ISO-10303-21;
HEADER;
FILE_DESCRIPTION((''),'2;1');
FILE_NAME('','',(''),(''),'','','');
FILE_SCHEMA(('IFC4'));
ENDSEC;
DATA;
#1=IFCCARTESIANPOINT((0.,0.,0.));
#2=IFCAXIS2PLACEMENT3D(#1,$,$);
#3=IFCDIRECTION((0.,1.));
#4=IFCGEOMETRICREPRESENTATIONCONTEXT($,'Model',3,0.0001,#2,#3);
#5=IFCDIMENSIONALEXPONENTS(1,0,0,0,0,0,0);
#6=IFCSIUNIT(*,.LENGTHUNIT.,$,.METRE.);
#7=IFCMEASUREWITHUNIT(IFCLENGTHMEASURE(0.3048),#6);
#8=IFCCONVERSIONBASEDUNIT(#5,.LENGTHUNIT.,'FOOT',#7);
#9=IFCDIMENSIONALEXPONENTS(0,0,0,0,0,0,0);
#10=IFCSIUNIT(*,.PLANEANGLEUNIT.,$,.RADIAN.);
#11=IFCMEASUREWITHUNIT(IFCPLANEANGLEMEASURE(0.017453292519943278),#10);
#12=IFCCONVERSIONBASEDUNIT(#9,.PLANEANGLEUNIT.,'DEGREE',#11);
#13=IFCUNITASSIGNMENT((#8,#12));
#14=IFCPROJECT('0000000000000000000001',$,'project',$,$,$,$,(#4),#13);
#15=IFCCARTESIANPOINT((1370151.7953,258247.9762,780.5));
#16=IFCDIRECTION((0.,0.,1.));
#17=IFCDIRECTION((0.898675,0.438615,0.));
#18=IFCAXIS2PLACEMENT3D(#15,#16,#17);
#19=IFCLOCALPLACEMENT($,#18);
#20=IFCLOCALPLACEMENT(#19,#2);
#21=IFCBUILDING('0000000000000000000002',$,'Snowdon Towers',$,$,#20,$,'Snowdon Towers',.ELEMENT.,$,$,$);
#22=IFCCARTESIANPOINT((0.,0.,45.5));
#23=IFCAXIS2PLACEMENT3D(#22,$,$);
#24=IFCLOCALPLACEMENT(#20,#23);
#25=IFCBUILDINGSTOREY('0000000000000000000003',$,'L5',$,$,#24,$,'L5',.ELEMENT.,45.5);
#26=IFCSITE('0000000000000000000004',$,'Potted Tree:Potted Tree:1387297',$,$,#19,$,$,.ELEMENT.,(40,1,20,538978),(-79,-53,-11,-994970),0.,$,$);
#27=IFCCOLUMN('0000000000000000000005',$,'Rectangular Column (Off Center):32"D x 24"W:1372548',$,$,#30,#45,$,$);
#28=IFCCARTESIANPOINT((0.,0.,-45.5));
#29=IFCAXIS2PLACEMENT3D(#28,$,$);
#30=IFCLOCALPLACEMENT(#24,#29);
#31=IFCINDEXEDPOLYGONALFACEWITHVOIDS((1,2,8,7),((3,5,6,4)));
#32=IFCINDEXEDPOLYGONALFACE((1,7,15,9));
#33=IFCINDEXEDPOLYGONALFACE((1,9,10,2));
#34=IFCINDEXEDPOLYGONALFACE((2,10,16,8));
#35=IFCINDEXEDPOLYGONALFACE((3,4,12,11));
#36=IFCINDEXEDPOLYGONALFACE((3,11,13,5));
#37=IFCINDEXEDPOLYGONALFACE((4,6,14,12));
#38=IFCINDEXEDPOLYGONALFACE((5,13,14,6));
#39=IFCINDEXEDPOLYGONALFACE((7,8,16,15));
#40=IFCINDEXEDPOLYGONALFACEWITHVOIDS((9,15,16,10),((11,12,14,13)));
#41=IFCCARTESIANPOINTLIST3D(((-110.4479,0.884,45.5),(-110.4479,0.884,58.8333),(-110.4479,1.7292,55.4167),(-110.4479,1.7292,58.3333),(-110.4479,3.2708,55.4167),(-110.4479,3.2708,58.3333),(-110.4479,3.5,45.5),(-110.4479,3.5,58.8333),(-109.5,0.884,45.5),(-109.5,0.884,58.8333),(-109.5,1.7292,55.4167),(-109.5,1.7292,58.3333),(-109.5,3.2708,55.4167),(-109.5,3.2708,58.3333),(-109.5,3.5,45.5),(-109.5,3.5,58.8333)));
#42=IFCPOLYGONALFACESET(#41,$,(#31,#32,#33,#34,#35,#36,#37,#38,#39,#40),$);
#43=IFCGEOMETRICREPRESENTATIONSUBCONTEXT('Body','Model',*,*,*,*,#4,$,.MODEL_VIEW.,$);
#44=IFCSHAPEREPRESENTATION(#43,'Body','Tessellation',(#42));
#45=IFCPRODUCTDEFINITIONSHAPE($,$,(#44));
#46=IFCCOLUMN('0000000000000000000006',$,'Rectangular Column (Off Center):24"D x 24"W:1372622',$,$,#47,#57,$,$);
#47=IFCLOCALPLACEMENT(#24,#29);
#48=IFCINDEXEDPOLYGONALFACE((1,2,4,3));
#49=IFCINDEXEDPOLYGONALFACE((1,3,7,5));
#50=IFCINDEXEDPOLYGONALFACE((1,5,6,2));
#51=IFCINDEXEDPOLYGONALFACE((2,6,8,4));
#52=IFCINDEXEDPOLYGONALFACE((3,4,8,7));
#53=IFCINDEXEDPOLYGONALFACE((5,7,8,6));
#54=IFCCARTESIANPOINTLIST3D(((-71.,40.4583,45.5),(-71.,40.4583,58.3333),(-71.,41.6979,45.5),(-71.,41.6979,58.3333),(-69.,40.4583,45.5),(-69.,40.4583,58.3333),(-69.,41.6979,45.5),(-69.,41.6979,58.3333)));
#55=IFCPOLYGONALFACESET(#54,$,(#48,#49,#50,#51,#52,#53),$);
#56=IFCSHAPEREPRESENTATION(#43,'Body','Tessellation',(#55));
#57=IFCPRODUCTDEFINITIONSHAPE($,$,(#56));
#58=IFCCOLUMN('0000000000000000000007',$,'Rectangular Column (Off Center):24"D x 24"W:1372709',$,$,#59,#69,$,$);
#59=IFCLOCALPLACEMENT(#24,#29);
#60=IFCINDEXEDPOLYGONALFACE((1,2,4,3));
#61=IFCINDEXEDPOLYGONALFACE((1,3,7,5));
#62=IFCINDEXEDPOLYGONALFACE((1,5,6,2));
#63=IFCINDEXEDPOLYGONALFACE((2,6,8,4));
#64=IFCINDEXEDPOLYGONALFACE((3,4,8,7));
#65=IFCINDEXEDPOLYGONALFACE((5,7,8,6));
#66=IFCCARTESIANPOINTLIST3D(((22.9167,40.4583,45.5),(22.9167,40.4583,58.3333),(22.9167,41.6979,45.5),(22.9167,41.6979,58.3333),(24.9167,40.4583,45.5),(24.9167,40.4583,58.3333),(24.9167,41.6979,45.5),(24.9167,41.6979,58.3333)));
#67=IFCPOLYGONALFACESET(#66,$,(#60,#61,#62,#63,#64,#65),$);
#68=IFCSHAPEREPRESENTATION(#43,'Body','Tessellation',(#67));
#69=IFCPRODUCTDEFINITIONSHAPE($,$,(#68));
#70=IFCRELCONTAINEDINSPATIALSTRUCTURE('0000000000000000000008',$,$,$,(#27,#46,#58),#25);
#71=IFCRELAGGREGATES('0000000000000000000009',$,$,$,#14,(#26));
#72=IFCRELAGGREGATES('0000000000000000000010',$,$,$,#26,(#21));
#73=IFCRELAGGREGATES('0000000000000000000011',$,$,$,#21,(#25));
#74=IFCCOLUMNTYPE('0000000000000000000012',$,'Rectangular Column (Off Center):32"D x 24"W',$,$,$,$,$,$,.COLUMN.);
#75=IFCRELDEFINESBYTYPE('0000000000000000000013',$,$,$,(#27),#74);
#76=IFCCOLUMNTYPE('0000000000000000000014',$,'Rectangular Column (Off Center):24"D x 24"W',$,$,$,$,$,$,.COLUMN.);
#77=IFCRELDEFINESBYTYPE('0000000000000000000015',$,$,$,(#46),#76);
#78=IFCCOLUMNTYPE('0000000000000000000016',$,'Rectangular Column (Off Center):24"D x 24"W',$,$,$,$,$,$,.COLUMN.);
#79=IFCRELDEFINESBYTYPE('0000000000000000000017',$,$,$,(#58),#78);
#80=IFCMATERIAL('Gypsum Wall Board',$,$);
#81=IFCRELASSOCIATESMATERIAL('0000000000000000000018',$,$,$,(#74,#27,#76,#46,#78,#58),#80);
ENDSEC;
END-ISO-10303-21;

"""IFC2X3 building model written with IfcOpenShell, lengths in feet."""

from ifc_helpers import new_model, entity, si_unit, converted_unit, direction, frame, frame_2d, origin, place, context, subcontext, project, spatial, rectangle, extrude, source, transform, mapped, material, type_object, type_shapes, element, save


model = new_model("IFC2X3")

# Units and contexts
model_context = context("Model", 3, precision=0.0001, world=origin(), true_north=direction((0.0, 1.0)))
body_context = subcontext(model_context, "Body", "Model", "MODEL_VIEW")
ifc_project = project(units=[converted_unit("LENGTHUNIT", "FOOT", entity("IfcLengthMeasure", 0.3048), si_unit("LENGTHUNIT", "METRE"), dimensions=[1, 0, 0, 0, 0, 0, 0]), converted_unit("PLANEANGLEUNIT", "DEGREE", entity("IfcPlaneAngleMeasure", 0.017453292519943278), si_unit("PLANEANGLEUNIT", "RADIAN"), dimensions=[0, 0, 0, 0, 0, 0, 0])], contexts=[model_context])

# Site, building, storey
site_placement = place(None, frame((1370151.7953, 258247.9762, 780.5), z_axis=(0.0, 0.0, 1.0), x_axis=(0.898675, 0.438615, 0.0)))
site = spatial("IfcSite", under=ifc_project, at=site_placement, Name="Potted Tree:Potted Tree:1387297", CompositionType="ELEMENT", RefLatitude=(40, 1, 20, 538978), RefLongitude=(-79, -53, -11, -994970), RefElevation=0.0)
building_placement = place(site_placement, origin())
building = spatial("IfcBuilding", under=site, at=building_placement, Name="Snowdon Towers", LongName="Snowdon Towers", CompositionType="ELEMENT")
storey_placement = place(building_placement, frame((0.0, 0.0, 45.5)))
storey = spatial("IfcBuildingStorey", under=building, at=storey_placement, Name="L5", LongName="L5", CompositionType="ELEMENT", Elevation=45.5)

# Shared definitions
ifc_material_1 = material(Name="Gypsum Wall Board")

# Column, opening
column_type_1 = type_object("IfcColumnType", Name="Rectangular Column (Off Center):32\"D x 24\"W", PredefinedType="COLUMN", material=ifc_material_1)
shared_shape_1 = source(origin(), body_context, "Body", "SweptSolid", [
    extrude(rectangle(XDim=2.616, YDim=0.9479, at=frame_2d((0.0, 0.0), x_axis=(1.0, 0.0))), frame((-109.974, 2.192, 45.5), z_axis=(0.0, 0.0, 1.0), x_axis=(0.0, -1.0, 0.0)), (0.0, 0.0, 1.0), 13.3333),
])
type_shapes(column_type_1, [shared_shape_1])
column_1_placement = place(storey_placement, frame((0.0, 0.0, -45.5)))
column_1 = element("IfcColumn", 1, at=column_1_placement, inside=storey, type_object=column_type_1, material=ifc_material_1, Name="Rectangular Column (Off Center):32\"D x 24\"W:1372548", context=body_context, shape_type="MappedRepresentation", body=[
    mapped(shared_shape_1, transform((0.0, 0.0, 0.0), scale=1.0)),
])
opening_placement = place(storey_placement, frame((0.0, 0.0, -45.5)))
element("IfcOpeningElement", 2, at=opening_placement, cuts=column_1, ObjectType="Opening", context=body_context, shape_type="SweptSolid", body=[
    extrude(rectangle(XDim=2.9167, YDim=1.5417, at=frame_2d((0.0, 0.0), x_axis=(1.0, 0.0))), frame((-110.4479, 2.5, 56.875), z_axis=(1.0, 0.0, 0.0), x_axis=(0.0, 0.0, 1.0)), (0.0, 0.0, 1.0), 0.9479),
])

# Columns
column_type_2 = type_object("IfcColumnType", Name="Rectangular Column (Off Center):24\"D x 24\"W", PredefinedType="COLUMN", material=ifc_material_1)
shared_shape_2 = source(origin(), body_context, "Body", "SweptSolid", [
    extrude(rectangle(XDim=1.2396, YDim=2.0, at=frame_2d((0.0, 0.0), x_axis=(1.0, 0.0))), frame((-70.0, 41.0781, 45.5), z_axis=(0.0, 0.0, 1.0), x_axis=(0.0, 1.0, 0.0)), (0.0, 0.0, 1.0), 12.8333),
])
type_shapes(column_type_2, [shared_shape_2])
column_2_placement = place(storey_placement, frame((0.0, 0.0, -45.5)))
element("IfcColumn", 3, at=column_2_placement, inside=storey, type_object=column_type_2, material=ifc_material_1, Name="Rectangular Column (Off Center):24\"D x 24\"W:1372622", context=body_context, shape_type="MappedRepresentation", body=[
    mapped(shared_shape_2, transform((0.0, 0.0, 0.0), scale=1.0)),
])
column_type_3 = type_object("IfcColumnType", Name="Rectangular Column (Off Center):24\"D x 24\"W", PredefinedType="COLUMN", material=ifc_material_1)
shared_shape_3 = source(origin(), body_context, "Body", "SweptSolid", [
    extrude(rectangle(XDim=1.2396, YDim=2.0, at=frame_2d((0.0, 0.0), x_axis=(1.0, 0.0))), frame((23.9167, 41.0781, 45.5), z_axis=(0.0, 0.0, 1.0), x_axis=(0.0, 1.0, 0.0)), (0.0, 0.0, 1.0), 12.8333),
])
type_shapes(column_type_3, [shared_shape_3])
column_3_placement = place(storey_placement, frame((0.0, 0.0, -45.5)))
element("IfcColumn", 4, at=column_3_placement, inside=storey, type_object=column_type_3, material=ifc_material_1, Name="Rectangular Column (Off Center):24\"D x 24\"W:1372709", context=body_context, shape_type="MappedRepresentation", body=[
    mapped(shared_shape_3, transform((0.0, 0.0, 0.0), scale=1.0)),
])

save(model, "model.ifc")
